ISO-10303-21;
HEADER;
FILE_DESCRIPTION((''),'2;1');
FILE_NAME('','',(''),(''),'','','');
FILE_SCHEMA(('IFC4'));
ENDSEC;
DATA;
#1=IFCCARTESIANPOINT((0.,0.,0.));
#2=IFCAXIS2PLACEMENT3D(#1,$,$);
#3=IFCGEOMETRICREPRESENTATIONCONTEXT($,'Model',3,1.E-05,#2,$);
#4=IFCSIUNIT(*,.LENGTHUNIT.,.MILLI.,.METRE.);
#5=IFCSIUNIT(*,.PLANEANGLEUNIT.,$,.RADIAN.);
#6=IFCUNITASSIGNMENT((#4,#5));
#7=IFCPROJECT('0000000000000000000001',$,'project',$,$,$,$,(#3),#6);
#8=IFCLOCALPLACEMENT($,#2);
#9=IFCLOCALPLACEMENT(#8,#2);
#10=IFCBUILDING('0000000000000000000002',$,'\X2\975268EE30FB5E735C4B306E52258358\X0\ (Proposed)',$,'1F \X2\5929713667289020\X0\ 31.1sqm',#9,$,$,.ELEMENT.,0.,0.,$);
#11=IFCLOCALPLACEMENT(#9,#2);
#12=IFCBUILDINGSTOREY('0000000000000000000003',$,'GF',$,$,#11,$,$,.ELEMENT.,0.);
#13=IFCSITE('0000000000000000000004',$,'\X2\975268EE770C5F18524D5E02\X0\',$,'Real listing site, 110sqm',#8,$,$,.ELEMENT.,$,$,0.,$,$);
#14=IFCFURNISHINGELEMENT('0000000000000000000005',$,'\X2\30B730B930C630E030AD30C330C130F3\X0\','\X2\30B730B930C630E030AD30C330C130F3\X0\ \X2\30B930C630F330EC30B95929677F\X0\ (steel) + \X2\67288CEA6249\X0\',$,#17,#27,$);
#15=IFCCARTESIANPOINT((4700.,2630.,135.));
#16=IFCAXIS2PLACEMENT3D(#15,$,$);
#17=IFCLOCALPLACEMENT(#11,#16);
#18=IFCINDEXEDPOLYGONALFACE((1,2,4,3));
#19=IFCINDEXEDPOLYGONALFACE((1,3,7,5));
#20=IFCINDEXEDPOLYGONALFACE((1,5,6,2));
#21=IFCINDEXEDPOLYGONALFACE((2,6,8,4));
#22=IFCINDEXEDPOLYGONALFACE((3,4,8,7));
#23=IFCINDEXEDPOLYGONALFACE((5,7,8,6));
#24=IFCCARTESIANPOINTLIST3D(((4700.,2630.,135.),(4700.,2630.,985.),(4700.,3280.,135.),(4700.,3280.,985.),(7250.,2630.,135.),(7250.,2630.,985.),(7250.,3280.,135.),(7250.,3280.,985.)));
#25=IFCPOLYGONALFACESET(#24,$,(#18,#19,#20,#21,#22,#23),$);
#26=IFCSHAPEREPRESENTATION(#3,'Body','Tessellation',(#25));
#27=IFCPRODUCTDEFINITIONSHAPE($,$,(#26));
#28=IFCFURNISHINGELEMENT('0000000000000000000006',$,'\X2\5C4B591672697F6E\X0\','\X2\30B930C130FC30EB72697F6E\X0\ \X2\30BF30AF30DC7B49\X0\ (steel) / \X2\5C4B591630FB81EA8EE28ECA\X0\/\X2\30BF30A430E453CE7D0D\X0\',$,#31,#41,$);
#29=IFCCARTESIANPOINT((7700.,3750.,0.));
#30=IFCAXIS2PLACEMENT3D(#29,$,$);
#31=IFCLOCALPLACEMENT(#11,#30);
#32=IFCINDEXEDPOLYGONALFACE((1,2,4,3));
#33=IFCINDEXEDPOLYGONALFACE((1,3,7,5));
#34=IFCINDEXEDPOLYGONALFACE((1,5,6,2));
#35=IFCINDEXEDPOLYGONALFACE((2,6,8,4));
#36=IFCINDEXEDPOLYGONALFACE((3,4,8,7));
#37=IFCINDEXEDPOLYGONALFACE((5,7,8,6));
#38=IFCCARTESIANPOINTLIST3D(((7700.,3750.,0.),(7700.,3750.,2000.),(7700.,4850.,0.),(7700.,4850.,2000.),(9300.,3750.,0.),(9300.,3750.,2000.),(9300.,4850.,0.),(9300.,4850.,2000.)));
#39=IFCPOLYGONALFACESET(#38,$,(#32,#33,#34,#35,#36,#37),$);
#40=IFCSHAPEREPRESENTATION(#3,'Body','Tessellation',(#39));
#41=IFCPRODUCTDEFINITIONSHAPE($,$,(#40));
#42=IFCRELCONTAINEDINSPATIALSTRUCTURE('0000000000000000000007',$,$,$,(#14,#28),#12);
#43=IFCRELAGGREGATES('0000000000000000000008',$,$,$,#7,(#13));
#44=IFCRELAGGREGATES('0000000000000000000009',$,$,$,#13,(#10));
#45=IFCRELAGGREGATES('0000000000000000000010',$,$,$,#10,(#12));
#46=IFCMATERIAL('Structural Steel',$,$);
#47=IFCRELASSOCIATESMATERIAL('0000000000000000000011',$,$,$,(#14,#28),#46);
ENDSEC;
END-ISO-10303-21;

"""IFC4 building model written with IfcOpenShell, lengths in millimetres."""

from ifc_helpers import new_model, si_unit, frame, frame_2d, origin, place, context, project, spatial, rectangle, extrude, material, element, save


model = new_model("IFC4")

# Units and contexts
model_context = context("Model", 3, precision=1e-05, world=origin())
ifc_project = project(units=[si_unit("LENGTHUNIT", "METRE", prefix="MILLI"), si_unit("PLANEANGLEUNIT", "RADIAN")], contexts=[model_context])

# Site, building, storey
site_placement = place(None, origin())
site = spatial("IfcSite", under=ifc_project, at=site_placement, Name="青森県弘前市", ObjectType="Real listing site, 110sqm", CompositionType="ELEMENT", RefElevation=0.0)
building_placement = place(site_placement, origin())
building = spatial("IfcBuilding", under=site, at=building_placement, Name="青森・平屋の別荘 (Proposed)", ObjectType="1F 天然木造 31.1sqm", CompositionType="ELEMENT", ElevationOfRefHeight=0.0, ElevationOfTerrain=0.0)
storey_placement = place(building_placement, origin())
storey = spatial("IfcBuildingStorey", under=building, at=storey_placement, Name="GF", CompositionType="ELEMENT", Elevation=0.0)

# Shared definitions
ifc_material_1 = material(Name="Structural Steel")

# Furnishing elements
furnishing_1_placement = place(storey_placement, frame((4700.0, 2630.0, 135.0)))
element("IfcFurnishingElement", 1, at=furnishing_1_placement, inside=storey, material=ifc_material_1, Name="システムキッチン", Description="システムキッチン ステンレス天板 (steel) + 木質扉", context=model_context, shape_type="SweptSolid", body=[
    extrude(rectangle(XDim=2550.0, YDim=650.0, at=frame_2d((1275.0, 325.0))), frame((4700.0, 2630.0, 135.0)), (0.0, 0.0, 1.0), 850.0),
])
furnishing_2_placement = place(storey_placement, frame((7700.0, 3750.0, 0.0)))
element("IfcFurnishingElement", 2, at=furnishing_2_placement, inside=storey, material=ifc_material_1, Name="屋外物置", Description="スチール物置 タクボ等 (steel) / 屋外・自転車/タイヤ収納", context=model_context, shape_type="SweptSolid", body=[
    extrude(rectangle(XDim=1600.0, YDim=1100.0, at=frame_2d((800.0, 550.0))), frame((7700.0, 3750.0, 0.0)), (0.0, 0.0, 1.0), 2000.0),
])

save(model, "model.ifc")
